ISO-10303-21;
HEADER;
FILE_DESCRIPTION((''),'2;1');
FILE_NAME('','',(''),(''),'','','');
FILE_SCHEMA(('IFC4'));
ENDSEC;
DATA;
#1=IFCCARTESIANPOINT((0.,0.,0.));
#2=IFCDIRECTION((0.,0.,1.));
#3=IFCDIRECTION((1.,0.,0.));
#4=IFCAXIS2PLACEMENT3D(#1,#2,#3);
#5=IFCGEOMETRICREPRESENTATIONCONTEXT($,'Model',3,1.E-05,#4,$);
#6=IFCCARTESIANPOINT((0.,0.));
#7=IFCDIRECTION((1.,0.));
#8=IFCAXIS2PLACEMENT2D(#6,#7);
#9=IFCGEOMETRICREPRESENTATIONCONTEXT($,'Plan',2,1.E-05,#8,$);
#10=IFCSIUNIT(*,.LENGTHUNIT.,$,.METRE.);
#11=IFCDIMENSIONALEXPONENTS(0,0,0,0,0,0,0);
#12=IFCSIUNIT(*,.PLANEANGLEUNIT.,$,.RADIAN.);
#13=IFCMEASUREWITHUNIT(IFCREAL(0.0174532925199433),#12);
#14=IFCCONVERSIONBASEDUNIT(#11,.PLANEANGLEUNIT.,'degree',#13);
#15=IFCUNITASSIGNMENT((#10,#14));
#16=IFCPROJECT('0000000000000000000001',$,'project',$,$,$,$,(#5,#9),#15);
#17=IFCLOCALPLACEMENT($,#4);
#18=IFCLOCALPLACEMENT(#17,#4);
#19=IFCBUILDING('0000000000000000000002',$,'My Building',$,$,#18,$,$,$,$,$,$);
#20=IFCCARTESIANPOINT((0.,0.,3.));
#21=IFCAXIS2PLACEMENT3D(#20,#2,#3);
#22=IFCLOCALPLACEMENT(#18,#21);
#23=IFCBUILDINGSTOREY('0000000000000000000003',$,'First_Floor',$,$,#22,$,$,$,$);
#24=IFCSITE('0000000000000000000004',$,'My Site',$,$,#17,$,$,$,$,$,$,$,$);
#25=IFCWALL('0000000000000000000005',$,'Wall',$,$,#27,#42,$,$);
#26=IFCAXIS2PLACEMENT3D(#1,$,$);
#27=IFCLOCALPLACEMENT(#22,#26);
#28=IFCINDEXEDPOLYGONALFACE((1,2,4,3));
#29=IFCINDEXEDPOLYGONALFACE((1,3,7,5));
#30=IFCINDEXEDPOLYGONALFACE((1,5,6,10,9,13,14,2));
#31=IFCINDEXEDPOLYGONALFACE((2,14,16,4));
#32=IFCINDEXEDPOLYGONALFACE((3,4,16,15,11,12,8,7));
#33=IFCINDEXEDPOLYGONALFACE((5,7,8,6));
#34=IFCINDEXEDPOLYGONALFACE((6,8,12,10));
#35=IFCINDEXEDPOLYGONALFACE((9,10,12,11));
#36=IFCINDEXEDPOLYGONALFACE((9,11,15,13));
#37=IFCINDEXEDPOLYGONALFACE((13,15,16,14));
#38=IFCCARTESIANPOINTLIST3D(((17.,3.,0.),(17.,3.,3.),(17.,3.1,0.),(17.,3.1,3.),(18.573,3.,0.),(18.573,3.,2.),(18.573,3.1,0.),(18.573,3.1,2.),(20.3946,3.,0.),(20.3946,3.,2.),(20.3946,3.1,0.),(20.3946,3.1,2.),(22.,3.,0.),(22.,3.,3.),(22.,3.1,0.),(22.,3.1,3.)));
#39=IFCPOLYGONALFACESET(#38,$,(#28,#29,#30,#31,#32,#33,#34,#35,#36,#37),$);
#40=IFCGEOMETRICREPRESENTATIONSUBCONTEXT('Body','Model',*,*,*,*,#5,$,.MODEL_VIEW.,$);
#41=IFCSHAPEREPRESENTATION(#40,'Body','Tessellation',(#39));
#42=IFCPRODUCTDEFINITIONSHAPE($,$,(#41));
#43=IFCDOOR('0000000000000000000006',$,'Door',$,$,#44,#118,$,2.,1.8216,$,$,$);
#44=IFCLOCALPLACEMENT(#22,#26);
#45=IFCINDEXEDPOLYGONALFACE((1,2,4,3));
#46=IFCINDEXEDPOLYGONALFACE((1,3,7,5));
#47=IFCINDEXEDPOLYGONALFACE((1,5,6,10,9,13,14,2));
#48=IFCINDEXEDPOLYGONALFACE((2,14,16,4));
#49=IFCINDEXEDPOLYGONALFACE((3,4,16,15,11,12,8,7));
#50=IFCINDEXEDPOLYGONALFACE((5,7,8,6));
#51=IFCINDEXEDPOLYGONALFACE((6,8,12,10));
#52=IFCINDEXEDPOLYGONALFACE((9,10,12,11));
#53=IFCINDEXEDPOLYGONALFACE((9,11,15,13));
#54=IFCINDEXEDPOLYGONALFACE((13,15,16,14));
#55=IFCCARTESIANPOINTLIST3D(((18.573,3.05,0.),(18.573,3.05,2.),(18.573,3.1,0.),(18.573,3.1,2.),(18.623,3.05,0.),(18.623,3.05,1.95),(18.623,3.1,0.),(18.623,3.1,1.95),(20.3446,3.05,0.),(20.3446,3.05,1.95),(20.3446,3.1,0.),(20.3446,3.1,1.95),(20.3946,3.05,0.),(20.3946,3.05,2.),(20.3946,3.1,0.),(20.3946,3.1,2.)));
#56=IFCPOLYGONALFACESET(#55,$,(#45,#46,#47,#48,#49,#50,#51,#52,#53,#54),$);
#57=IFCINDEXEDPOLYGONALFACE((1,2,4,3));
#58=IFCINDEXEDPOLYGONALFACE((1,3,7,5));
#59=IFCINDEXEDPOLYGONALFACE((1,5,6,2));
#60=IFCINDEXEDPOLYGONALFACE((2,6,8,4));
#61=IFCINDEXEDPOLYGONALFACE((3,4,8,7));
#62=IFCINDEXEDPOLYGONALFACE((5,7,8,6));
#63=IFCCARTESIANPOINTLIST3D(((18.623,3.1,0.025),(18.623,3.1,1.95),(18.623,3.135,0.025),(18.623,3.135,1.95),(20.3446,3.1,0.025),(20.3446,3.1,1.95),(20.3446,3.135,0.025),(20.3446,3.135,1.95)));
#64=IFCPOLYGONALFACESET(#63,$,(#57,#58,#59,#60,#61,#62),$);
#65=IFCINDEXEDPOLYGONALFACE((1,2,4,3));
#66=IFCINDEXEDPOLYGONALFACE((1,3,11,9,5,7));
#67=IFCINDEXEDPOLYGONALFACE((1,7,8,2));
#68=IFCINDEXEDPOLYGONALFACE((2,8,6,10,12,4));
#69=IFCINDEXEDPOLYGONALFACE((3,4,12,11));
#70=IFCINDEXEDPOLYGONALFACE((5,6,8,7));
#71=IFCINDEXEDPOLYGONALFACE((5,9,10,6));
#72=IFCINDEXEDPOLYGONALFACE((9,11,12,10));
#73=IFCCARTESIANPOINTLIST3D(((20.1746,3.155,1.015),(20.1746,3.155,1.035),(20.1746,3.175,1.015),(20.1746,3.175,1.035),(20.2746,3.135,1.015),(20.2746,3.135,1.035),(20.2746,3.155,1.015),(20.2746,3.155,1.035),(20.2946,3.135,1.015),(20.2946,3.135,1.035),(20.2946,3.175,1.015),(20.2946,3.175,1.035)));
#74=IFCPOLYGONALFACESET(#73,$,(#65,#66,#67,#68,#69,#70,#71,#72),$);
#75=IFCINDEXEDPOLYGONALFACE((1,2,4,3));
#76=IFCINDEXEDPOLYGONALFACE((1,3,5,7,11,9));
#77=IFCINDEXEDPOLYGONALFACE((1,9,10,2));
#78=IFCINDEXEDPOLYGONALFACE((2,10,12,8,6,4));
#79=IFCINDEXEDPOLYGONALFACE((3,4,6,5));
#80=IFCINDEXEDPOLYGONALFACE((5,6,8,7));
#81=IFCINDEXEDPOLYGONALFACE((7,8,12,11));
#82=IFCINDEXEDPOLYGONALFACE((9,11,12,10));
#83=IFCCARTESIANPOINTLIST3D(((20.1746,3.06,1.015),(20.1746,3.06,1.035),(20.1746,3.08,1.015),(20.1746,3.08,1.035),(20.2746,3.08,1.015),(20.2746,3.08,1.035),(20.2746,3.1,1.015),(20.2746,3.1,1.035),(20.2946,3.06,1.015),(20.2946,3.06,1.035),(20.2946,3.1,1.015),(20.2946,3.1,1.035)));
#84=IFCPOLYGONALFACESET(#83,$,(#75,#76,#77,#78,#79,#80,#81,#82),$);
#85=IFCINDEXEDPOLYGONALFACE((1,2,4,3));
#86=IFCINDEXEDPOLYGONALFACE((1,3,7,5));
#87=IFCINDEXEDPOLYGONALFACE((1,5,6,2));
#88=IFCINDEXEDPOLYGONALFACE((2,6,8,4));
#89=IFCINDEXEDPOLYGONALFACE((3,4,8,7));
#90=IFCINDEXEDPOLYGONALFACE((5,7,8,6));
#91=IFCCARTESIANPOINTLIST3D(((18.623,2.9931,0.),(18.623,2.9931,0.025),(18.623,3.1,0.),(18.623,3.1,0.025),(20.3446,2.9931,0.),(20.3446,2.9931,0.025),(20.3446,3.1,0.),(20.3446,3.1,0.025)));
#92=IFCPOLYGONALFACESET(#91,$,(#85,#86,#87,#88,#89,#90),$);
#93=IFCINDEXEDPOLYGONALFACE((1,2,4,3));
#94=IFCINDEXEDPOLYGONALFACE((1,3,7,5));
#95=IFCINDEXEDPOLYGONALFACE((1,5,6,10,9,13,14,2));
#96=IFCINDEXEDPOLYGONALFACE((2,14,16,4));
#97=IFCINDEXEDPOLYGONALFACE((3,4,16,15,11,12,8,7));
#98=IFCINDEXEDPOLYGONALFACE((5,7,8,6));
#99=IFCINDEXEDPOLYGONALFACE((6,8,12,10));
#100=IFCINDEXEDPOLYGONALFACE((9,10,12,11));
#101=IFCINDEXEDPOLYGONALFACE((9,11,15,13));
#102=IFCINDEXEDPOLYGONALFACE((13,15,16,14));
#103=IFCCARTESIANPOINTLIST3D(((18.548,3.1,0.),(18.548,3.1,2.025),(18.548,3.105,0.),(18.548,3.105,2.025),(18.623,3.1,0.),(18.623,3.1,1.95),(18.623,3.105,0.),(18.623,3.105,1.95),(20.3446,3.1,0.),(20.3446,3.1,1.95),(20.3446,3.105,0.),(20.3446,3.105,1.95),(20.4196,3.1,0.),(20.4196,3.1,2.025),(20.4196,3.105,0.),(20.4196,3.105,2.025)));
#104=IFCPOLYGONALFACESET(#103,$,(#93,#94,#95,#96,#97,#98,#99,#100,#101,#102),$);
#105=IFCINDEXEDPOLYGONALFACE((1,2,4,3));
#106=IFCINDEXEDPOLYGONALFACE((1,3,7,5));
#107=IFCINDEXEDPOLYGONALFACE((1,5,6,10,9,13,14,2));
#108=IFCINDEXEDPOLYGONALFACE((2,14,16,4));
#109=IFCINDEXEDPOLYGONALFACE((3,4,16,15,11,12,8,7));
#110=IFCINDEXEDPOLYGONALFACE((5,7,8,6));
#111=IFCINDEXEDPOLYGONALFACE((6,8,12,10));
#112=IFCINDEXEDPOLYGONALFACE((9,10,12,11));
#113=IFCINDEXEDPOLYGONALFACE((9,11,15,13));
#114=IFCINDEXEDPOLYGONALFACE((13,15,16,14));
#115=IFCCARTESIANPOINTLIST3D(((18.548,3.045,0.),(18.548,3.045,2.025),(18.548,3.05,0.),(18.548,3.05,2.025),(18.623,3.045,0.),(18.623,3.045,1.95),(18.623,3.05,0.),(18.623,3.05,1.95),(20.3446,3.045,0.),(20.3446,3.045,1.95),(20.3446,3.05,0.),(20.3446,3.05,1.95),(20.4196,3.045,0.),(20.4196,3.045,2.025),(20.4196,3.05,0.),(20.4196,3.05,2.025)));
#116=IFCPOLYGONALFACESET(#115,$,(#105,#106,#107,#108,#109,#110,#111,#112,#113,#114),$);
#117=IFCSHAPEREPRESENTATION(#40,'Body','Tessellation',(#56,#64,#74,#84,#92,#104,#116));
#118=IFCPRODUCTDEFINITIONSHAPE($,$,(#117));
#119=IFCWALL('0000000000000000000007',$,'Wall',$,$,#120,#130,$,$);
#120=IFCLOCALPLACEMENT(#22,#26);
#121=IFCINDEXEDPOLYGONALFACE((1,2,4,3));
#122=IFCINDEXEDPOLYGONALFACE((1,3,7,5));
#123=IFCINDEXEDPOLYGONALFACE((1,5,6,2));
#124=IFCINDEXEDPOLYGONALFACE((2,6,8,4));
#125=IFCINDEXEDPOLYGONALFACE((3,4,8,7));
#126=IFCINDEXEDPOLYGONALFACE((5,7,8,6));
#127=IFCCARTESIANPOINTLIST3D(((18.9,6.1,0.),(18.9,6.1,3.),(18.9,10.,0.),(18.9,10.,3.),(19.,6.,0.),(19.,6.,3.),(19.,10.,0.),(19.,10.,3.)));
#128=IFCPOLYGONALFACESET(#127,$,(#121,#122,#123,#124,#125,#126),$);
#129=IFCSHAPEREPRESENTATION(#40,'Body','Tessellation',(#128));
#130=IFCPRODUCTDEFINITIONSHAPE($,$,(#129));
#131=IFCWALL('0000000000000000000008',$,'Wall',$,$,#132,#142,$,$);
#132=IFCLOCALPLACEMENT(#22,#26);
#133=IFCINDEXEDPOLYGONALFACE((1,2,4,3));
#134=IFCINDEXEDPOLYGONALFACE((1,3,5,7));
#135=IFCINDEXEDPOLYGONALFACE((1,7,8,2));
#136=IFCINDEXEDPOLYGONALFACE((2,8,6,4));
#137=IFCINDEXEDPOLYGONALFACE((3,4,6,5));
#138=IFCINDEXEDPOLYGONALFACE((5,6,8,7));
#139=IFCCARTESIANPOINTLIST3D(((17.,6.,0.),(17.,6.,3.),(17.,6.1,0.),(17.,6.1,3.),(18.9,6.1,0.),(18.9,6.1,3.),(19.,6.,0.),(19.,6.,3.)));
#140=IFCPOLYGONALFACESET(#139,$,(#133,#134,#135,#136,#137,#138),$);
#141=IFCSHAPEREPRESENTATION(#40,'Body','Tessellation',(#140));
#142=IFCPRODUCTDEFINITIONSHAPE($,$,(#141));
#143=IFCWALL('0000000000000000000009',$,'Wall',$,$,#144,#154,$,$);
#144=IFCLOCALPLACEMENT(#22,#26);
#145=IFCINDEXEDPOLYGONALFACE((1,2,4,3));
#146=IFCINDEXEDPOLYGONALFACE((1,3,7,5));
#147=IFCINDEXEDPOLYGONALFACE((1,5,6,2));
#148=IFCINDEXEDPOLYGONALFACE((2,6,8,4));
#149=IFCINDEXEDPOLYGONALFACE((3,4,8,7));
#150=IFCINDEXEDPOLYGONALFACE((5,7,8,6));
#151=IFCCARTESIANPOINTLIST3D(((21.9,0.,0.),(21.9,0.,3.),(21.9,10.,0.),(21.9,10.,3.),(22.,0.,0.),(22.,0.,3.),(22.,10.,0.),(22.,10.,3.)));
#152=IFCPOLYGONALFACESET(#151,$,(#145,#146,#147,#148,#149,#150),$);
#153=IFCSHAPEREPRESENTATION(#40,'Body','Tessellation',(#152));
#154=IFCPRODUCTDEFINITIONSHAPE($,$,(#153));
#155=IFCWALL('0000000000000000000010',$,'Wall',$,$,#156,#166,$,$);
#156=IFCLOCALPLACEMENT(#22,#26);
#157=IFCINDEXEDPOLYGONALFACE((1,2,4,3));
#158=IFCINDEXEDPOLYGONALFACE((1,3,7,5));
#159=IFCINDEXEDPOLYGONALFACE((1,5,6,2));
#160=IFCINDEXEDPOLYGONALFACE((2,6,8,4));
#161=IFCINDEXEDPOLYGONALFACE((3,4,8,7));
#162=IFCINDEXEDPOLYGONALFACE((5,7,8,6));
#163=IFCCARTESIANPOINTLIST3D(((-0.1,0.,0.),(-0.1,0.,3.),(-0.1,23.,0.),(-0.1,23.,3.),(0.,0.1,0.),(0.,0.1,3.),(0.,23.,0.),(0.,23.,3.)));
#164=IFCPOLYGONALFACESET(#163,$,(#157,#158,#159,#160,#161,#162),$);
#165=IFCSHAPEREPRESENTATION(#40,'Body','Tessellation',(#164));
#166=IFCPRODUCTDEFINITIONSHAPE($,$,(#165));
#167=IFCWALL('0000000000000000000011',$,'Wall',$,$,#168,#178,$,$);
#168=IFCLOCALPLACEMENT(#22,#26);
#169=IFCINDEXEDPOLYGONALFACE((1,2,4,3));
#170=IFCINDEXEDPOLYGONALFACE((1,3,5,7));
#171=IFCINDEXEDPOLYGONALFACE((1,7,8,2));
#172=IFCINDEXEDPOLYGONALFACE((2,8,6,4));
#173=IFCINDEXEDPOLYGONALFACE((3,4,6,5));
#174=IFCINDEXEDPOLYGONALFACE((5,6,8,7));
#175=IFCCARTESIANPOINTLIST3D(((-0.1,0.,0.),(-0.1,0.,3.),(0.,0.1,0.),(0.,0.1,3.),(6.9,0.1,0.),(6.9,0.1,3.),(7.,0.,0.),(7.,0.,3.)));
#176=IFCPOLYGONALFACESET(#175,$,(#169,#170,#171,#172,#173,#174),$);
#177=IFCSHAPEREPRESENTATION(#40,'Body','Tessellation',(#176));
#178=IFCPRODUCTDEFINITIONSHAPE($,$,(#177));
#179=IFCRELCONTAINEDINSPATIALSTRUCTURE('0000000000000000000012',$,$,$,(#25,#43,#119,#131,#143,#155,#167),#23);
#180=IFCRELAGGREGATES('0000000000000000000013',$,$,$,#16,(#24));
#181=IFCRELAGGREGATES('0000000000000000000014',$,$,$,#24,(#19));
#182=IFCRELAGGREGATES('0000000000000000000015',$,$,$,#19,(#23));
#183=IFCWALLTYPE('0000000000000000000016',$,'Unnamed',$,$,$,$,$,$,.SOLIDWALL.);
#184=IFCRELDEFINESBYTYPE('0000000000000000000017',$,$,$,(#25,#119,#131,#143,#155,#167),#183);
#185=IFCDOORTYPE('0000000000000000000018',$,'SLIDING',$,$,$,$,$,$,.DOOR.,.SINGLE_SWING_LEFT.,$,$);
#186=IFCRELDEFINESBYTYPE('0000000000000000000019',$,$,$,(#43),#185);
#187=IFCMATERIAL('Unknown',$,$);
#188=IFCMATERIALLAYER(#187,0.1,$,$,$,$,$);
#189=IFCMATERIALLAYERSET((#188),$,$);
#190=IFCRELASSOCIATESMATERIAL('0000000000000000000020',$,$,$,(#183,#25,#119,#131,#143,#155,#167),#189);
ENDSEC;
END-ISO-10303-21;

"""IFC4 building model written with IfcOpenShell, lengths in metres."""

from ifc_helpers import new_model, entity, si_unit, converted_unit, frame, origin_with_axes, origin_2d_with_axis, place, context, subcontext, project, spatial, line, indexed_curve, outline, extrude, shape, source, transform, mapped, material, layer, layer_set, layer_usage, type_object, type_shapes, element, fill, save


model = new_model("IFC4")

# Units and contexts
model_context = context("Model", 3, precision=1e-05, world=origin_with_axes())
plan_context = context("Plan", 2, precision=1e-05, world=origin_2d_with_axis())
body_context_1 = subcontext(model_context, "Body", "Model", "MODEL_VIEW")
body_context_2 = subcontext(plan_context, "Body", "Plan", "PLAN_VIEW")
ifc_project = project(units=[si_unit("LENGTHUNIT", "METRE"), converted_unit("PLANEANGLEUNIT", "degree", entity("IfcReal", 0.0174532925199433), si_unit("PLANEANGLEUNIT", "RADIAN"), dimensions=[0, 0, 0, 0, 0, 0, 0])], contexts=[model_context, plan_context])

# Site, building, storey
site_placement = place(None, origin_with_axes())
site = spatial("IfcSite", under=ifc_project, at=site_placement, Name="My Site")
building_placement = place(site_placement, origin_with_axes())
building = spatial("IfcBuilding", under=site, at=building_placement, Name="My Building")
storey_placement = place(building_placement, frame((0.0, 0.0, 3.0), z_axis=(0.0, 0.0, 1.0), x_axis=(1.0, 0.0, 0.0)))
storey = spatial("IfcBuildingStorey", under=building, at=storey_placement, Name="First_Floor")

# Shared definitions
ifc_material = material(Name="Unknown")
ifc_layer = layer(ifc_material, 0.1)
ifc_layer_set = layer_set([ifc_layer])
wall_type = type_object("IfcWallType", Name="Unnamed", PredefinedType="SOLIDWALL", material=ifc_layer_set)

# Shared definitions
shared_shape_1 = source(origin_with_axes(), body_context_1, "Body", "SweptSolid", [
    extrude(outline(indexed_curve([(0.0, 0.0), (1.8216, 0.0), (1.8216, 2.0), (0.0, 2.0)], segments=[line(1, 2, 3, 4, 1)])), frame((0.0, -0.6, 0.0), z_axis=(0.0, -1.0, 0.0), x_axis=(1.0, 0.0, 0.0)), (0.0, 0.0, -1.0), 1.2),
])
door_type_1 = type_object("IfcDoorType", Name="SLIDING", OperationType="SINGLE_SWING_LEFT", PredefinedType="DOOR")
shared_shape_2 = source(origin_with_axes(), body_context_1, "Body", "SweptSolid", [
    extrude(outline(indexed_curve([(0.0, 0.0), (0.0, 2.0), (1.8216, 2.0), (1.8216, 0.0), (1.7716, 0.0), (1.7716, 1.95), (0.05, 1.95), (0.05, 0.0)], segments=[line(1, 2, 3, 4, 5, 6, 7, 8, 1)])), frame((0.0, 0.0, 0.0), z_axis=(0.0, -1.0, 0.0), x_axis=(1.0, 0.0, 0.0)), (0.0, 0.0, -1.0), 0.05),
    extrude(outline(indexed_curve([(0.0, 0.0), (1.7216, 0.0), (1.7216, 0.035), (0.0, 0.035)], segments=[line(1, 2, 3, 4, 1)])), frame((0.05, -0.035, 0.025), z_axis=(0.0, 0.0, 1.0), x_axis=(1.0, 0.0, 0.0)), (0.0, 0.0, 1.0), 1.925),
    extrude(outline(indexed_curve([(0.0, 0.0), (0.0, -0.04), (0.12, -0.04), (0.12, -0.02), (0.02, -0.02), (0.02, 0.0)], segments=[line(1, 2, 3, 4, 5, 6, 1)])), frame((0.1, -0.035, 1.015), z_axis=(0.0, 0.0, 1.0), x_axis=(1.0, 0.0, 0.0)), (0.0, 0.0, 1.0), 0.02),
    extrude(outline(indexed_curve([(0.0, 0.0), (0.0, 0.04), (0.12, 0.04), (0.12, 0.02), (0.02, 0.02), (0.02, 0.0)], segments=[line(1, 2, 3, 4, 5, 6, 1)])), frame((0.1, 0.0, 1.015), z_axis=(0.0, 0.0, 1.0), x_axis=(1.0, 0.0, 0.0)), (0.0, 0.0, 1.0), 0.02),
    extrude(outline(indexed_curve([(0.0, 0.0), (1.7216, 0.0), (1.7216, 0.1069), (0.0, 0.1069)], segments=[line(1, 2, 3, 4, 1)])), frame((0.05, 0.0, 0.0), z_axis=(0.0, 0.0, 1.0), x_axis=(1.0, 0.0, 0.0)), (0.0, 0.0, 1.0), 0.025),
    extrude(outline(indexed_curve([(0.0, 0.0), (0.0, 2.025), (1.8716, 2.025), (1.8716, 0.0), (1.7966, 0.0), (1.7966, 1.95), (0.075, 1.95), (0.075, 0.0)], segments=[line(1, 2, 3, 4, 5, 6, 7, 8, 1)])), frame((-0.025, -0.005, 0.0), z_axis=(0.0, -1.0, 0.0), x_axis=(1.0, 0.0, 0.0)), (0.0, 0.0, -1.0), 0.005),
    extrude(outline(indexed_curve([(0.0, 0.0), (0.0, 2.025), (1.8716, 2.025), (1.8716, 0.0), (1.7966, 0.0), (1.7966, 1.95), (0.075, 1.95), (0.075, 0.0)], segments=[line(1, 2, 3, 4, 5, 6, 7, 8, 1)])), frame((-0.025, 0.05, 0.0), z_axis=(0.0, -1.0, 0.0), x_axis=(1.0, 0.0, 0.0)), (0.0, 0.0, -1.0), 0.005),
])
shared_shape_3 = source(origin_with_axes(), body_context_2, "Body", "Curve2D", [
    entity("IfcIndexedPolyCurve", entity("IfcCartesianPointList2D", [[0.0, 0.0], [0.05, 0.0], [0.05, 0.05], [0.0, 0.05]]), [entity("IfcLineIndex", [1, 2, 3, 4, 1])]),
    entity("IfcIndexedPolyCurve", entity("IfcCartesianPointList2D", [[1.8216, 0.0], [1.7716, 0.0], [1.7716, 0.05], [1.8216, 0.05]]), [entity("IfcLineIndex", [1, 2, 3, 4, 1])]),
    entity("IfcIndexedPolyCurve", entity("IfcCartesianPointList2D", [[2.6325, -0.035], [0.9108, -0.035], [0.9108, 0.0], [2.6325, 0.0]]), [entity("IfcLineIndex", [1, 2, 3, 4, 1])]),
])
type_shapes(door_type_1, [shared_shape_2, shared_shape_3])

# Wall, opening, door
ifc_layer_usage_1 = layer_usage(ifc_layer_set, "AXIS2", "POSITIVE", 0.0)
wall_1_placement = place(storey_placement, frame((17.0, 3.0, 0.0), z_axis=(0.0, 0.0, 1.0), x_axis=(1.0, 0.0, 0.0)))
wall_1 = element("IfcWall", 1, at=wall_1_placement, inside=storey, type_object=wall_type, material=ifc_layer_usage_1, Name="Wall", context=body_context_1, shape_type="SweptSolid", body=[
    extrude(outline(indexed_curve([(0.0, 0.0), (0.0, 0.1), (5.0, 0.1), (5.0, 0.0)], segments=[line(1, 2, 3, 4, 1)])), origin_with_axes(), (0.0, 0.0, 1.0), 3.0),
])
opening_1_placement = place(wall_1_placement, frame((3.3946, 0.1, 0.0), z_axis=(0.0, 0.0, 1.0), x_axis=(-1.0, 0.0, 0.0)))
opening_1 = element("IfcOpeningElement", 2, at=opening_1_placement, cuts=wall_1, PredefinedType="OPENING", context=body_context_1, shape_type="MappedRepresentation", body=[
    mapped(shared_shape_1, transform((0.0, 0.0, 0.0), x_axis=(1.0, 0.0, 0.0), y_axis=(0.0, 1.0, 0.0), z_axis=(0.0, 0.0, 1.0), scale=1.0)),
])
door_1_placement = place(opening_1_placement, origin_with_axes())
door_1 = element("IfcDoor", 3, at=door_1_placement, inside=storey, type_object=door_type_1, Name="Door", OverallHeight=2.0, OverallWidth=1.8216, shapes=[
    shape(body_context_1, "Body", "MappedRepresentation", [mapped(shared_shape_2, transform((0.0, 0.0, 0.0), x_axis=(1.0, 0.0, 0.0), y_axis=(0.0, 1.0, 0.0), z_axis=(0.0, 0.0, 1.0), scale=1.0))]),
    shape(body_context_2, "Body", "MappedRepresentation", [mapped(shared_shape_3, transform((0.0, 0.0, 0.0), x_axis=(1.0, 0.0, 0.0), y_axis=(0.0, 1.0, 0.0), z_axis=(0.0, 0.0, 1.0), scale=1.0))]),
])
fill(opening_1, door_1)

# Walls
ifc_layer_usage_2 = layer_usage(ifc_layer_set, "AXIS2", "POSITIVE", 0.0)
wall_2_placement = place(storey_placement, frame((19.0, 6.0, 0.0), z_axis=(0.0, 0.0, 1.0), x_axis=(0.0, 1.0, 0.0)))
element("IfcWall", 4, at=wall_2_placement, inside=storey, type_object=wall_type, material=ifc_layer_usage_2, Name="Wall", context=body_context_1, shape_type="SweptSolid", body=[
    extrude(outline(indexed_curve([(0.0, 0.0), (0.1, 0.1), (4.0, 0.1), (4.0, 0.0)], segments=[line(1, 2, 3, 4, 1)])), origin_with_axes(), (0.0, 0.0, 1.0), 3.0),
])
ifc_layer_usage_3 = layer_usage(ifc_layer_set, "AXIS2", "POSITIVE", 0.0)
wall_3_placement = place(storey_placement, frame((17.0, 6.0, 0.0), z_axis=(0.0, 0.0, 1.0), x_axis=(1.0, 0.0, 0.0)))
element("IfcWall", 5, at=wall_3_placement, inside=storey, type_object=wall_type, material=ifc_layer_usage_3, Name="Wall", context=body_context_1, shape_type="SweptSolid", body=[
    extrude(outline(indexed_curve([(0.0, 0.0), (0.0, 0.1), (1.9, 0.1), (2.0, 0.0)], segments=[line(1, 2, 3, 4, 1)])), origin_with_axes(), (0.0, 0.0, 1.0), 3.0),
])
ifc_layer_usage_4 = layer_usage(ifc_layer_set, "AXIS2", "POSITIVE", 0.0)
wall_4_placement = place(storey_placement, frame((21.9, 10.0, 0.0), z_axis=(0.0, 0.0, 1.0), x_axis=(0.0, -1.0, 0.0)))
element("IfcWall", 6, at=wall_4_placement, inside=storey, type_object=wall_type, material=ifc_layer_usage_4, Name="Wall", context=body_context_1, shape_type="SweptSolid", body=[
    extrude(outline(indexed_curve([(0.0, 0.0), (0.0, 0.1), (10.0, 0.1), (10.0, 0.0)], segments=[line(1, 2, 3, 4, 1)])), origin_with_axes(), (0.0, 0.0, 1.0), 3.0),
])
ifc_layer_usage_5 = layer_usage(ifc_layer_set, "AXIS2", "POSITIVE", 0.0)
wall_5_placement = place(storey_placement, frame((0.0, 0.1, 0.0), z_axis=(0.0, 0.0, 1.0), x_axis=(0.0, 1.0, 0.0)))
element("IfcWall", 7, at=wall_5_placement, inside=storey, type_object=wall_type, material=ifc_layer_usage_5, Name="Wall", context=body_context_1, shape_type="SweptSolid", body=[
    extrude(outline(indexed_curve([(0.0, 0.0), (-0.1, 0.1), (22.9, 0.1), (22.9, 0.0)], segments=[line(1, 2, 3, 4, 1)])), origin_with_axes(), (0.0, 0.0, 1.0), 3.0),
])

# Wall
ifc_layer_usage_6 = layer_usage(ifc_layer_set, "AXIS2", "POSITIVE", 0.0)
wall_6_placement = place(storey_placement, frame((6.9, 0.1, 0.0), z_axis=(0.0, 0.0, 1.0), x_axis=(-1.0, 0.0, 0.0)))
element("IfcWall", 8, at=wall_6_placement, inside=storey, type_object=wall_type, material=ifc_layer_usage_6, Name="Wall", context=body_context_1, shape_type="SweptSolid", body=[
    extrude(outline(indexed_curve([(0.0, 0.0), (-0.1, 0.1), (7.0, 0.1), (6.9, 0.0)], segments=[line(1, 2, 3, 4, 1)])), origin_with_axes(), (0.0, 0.0, 1.0), 3.0),
])

save(model, "model.ifc")
